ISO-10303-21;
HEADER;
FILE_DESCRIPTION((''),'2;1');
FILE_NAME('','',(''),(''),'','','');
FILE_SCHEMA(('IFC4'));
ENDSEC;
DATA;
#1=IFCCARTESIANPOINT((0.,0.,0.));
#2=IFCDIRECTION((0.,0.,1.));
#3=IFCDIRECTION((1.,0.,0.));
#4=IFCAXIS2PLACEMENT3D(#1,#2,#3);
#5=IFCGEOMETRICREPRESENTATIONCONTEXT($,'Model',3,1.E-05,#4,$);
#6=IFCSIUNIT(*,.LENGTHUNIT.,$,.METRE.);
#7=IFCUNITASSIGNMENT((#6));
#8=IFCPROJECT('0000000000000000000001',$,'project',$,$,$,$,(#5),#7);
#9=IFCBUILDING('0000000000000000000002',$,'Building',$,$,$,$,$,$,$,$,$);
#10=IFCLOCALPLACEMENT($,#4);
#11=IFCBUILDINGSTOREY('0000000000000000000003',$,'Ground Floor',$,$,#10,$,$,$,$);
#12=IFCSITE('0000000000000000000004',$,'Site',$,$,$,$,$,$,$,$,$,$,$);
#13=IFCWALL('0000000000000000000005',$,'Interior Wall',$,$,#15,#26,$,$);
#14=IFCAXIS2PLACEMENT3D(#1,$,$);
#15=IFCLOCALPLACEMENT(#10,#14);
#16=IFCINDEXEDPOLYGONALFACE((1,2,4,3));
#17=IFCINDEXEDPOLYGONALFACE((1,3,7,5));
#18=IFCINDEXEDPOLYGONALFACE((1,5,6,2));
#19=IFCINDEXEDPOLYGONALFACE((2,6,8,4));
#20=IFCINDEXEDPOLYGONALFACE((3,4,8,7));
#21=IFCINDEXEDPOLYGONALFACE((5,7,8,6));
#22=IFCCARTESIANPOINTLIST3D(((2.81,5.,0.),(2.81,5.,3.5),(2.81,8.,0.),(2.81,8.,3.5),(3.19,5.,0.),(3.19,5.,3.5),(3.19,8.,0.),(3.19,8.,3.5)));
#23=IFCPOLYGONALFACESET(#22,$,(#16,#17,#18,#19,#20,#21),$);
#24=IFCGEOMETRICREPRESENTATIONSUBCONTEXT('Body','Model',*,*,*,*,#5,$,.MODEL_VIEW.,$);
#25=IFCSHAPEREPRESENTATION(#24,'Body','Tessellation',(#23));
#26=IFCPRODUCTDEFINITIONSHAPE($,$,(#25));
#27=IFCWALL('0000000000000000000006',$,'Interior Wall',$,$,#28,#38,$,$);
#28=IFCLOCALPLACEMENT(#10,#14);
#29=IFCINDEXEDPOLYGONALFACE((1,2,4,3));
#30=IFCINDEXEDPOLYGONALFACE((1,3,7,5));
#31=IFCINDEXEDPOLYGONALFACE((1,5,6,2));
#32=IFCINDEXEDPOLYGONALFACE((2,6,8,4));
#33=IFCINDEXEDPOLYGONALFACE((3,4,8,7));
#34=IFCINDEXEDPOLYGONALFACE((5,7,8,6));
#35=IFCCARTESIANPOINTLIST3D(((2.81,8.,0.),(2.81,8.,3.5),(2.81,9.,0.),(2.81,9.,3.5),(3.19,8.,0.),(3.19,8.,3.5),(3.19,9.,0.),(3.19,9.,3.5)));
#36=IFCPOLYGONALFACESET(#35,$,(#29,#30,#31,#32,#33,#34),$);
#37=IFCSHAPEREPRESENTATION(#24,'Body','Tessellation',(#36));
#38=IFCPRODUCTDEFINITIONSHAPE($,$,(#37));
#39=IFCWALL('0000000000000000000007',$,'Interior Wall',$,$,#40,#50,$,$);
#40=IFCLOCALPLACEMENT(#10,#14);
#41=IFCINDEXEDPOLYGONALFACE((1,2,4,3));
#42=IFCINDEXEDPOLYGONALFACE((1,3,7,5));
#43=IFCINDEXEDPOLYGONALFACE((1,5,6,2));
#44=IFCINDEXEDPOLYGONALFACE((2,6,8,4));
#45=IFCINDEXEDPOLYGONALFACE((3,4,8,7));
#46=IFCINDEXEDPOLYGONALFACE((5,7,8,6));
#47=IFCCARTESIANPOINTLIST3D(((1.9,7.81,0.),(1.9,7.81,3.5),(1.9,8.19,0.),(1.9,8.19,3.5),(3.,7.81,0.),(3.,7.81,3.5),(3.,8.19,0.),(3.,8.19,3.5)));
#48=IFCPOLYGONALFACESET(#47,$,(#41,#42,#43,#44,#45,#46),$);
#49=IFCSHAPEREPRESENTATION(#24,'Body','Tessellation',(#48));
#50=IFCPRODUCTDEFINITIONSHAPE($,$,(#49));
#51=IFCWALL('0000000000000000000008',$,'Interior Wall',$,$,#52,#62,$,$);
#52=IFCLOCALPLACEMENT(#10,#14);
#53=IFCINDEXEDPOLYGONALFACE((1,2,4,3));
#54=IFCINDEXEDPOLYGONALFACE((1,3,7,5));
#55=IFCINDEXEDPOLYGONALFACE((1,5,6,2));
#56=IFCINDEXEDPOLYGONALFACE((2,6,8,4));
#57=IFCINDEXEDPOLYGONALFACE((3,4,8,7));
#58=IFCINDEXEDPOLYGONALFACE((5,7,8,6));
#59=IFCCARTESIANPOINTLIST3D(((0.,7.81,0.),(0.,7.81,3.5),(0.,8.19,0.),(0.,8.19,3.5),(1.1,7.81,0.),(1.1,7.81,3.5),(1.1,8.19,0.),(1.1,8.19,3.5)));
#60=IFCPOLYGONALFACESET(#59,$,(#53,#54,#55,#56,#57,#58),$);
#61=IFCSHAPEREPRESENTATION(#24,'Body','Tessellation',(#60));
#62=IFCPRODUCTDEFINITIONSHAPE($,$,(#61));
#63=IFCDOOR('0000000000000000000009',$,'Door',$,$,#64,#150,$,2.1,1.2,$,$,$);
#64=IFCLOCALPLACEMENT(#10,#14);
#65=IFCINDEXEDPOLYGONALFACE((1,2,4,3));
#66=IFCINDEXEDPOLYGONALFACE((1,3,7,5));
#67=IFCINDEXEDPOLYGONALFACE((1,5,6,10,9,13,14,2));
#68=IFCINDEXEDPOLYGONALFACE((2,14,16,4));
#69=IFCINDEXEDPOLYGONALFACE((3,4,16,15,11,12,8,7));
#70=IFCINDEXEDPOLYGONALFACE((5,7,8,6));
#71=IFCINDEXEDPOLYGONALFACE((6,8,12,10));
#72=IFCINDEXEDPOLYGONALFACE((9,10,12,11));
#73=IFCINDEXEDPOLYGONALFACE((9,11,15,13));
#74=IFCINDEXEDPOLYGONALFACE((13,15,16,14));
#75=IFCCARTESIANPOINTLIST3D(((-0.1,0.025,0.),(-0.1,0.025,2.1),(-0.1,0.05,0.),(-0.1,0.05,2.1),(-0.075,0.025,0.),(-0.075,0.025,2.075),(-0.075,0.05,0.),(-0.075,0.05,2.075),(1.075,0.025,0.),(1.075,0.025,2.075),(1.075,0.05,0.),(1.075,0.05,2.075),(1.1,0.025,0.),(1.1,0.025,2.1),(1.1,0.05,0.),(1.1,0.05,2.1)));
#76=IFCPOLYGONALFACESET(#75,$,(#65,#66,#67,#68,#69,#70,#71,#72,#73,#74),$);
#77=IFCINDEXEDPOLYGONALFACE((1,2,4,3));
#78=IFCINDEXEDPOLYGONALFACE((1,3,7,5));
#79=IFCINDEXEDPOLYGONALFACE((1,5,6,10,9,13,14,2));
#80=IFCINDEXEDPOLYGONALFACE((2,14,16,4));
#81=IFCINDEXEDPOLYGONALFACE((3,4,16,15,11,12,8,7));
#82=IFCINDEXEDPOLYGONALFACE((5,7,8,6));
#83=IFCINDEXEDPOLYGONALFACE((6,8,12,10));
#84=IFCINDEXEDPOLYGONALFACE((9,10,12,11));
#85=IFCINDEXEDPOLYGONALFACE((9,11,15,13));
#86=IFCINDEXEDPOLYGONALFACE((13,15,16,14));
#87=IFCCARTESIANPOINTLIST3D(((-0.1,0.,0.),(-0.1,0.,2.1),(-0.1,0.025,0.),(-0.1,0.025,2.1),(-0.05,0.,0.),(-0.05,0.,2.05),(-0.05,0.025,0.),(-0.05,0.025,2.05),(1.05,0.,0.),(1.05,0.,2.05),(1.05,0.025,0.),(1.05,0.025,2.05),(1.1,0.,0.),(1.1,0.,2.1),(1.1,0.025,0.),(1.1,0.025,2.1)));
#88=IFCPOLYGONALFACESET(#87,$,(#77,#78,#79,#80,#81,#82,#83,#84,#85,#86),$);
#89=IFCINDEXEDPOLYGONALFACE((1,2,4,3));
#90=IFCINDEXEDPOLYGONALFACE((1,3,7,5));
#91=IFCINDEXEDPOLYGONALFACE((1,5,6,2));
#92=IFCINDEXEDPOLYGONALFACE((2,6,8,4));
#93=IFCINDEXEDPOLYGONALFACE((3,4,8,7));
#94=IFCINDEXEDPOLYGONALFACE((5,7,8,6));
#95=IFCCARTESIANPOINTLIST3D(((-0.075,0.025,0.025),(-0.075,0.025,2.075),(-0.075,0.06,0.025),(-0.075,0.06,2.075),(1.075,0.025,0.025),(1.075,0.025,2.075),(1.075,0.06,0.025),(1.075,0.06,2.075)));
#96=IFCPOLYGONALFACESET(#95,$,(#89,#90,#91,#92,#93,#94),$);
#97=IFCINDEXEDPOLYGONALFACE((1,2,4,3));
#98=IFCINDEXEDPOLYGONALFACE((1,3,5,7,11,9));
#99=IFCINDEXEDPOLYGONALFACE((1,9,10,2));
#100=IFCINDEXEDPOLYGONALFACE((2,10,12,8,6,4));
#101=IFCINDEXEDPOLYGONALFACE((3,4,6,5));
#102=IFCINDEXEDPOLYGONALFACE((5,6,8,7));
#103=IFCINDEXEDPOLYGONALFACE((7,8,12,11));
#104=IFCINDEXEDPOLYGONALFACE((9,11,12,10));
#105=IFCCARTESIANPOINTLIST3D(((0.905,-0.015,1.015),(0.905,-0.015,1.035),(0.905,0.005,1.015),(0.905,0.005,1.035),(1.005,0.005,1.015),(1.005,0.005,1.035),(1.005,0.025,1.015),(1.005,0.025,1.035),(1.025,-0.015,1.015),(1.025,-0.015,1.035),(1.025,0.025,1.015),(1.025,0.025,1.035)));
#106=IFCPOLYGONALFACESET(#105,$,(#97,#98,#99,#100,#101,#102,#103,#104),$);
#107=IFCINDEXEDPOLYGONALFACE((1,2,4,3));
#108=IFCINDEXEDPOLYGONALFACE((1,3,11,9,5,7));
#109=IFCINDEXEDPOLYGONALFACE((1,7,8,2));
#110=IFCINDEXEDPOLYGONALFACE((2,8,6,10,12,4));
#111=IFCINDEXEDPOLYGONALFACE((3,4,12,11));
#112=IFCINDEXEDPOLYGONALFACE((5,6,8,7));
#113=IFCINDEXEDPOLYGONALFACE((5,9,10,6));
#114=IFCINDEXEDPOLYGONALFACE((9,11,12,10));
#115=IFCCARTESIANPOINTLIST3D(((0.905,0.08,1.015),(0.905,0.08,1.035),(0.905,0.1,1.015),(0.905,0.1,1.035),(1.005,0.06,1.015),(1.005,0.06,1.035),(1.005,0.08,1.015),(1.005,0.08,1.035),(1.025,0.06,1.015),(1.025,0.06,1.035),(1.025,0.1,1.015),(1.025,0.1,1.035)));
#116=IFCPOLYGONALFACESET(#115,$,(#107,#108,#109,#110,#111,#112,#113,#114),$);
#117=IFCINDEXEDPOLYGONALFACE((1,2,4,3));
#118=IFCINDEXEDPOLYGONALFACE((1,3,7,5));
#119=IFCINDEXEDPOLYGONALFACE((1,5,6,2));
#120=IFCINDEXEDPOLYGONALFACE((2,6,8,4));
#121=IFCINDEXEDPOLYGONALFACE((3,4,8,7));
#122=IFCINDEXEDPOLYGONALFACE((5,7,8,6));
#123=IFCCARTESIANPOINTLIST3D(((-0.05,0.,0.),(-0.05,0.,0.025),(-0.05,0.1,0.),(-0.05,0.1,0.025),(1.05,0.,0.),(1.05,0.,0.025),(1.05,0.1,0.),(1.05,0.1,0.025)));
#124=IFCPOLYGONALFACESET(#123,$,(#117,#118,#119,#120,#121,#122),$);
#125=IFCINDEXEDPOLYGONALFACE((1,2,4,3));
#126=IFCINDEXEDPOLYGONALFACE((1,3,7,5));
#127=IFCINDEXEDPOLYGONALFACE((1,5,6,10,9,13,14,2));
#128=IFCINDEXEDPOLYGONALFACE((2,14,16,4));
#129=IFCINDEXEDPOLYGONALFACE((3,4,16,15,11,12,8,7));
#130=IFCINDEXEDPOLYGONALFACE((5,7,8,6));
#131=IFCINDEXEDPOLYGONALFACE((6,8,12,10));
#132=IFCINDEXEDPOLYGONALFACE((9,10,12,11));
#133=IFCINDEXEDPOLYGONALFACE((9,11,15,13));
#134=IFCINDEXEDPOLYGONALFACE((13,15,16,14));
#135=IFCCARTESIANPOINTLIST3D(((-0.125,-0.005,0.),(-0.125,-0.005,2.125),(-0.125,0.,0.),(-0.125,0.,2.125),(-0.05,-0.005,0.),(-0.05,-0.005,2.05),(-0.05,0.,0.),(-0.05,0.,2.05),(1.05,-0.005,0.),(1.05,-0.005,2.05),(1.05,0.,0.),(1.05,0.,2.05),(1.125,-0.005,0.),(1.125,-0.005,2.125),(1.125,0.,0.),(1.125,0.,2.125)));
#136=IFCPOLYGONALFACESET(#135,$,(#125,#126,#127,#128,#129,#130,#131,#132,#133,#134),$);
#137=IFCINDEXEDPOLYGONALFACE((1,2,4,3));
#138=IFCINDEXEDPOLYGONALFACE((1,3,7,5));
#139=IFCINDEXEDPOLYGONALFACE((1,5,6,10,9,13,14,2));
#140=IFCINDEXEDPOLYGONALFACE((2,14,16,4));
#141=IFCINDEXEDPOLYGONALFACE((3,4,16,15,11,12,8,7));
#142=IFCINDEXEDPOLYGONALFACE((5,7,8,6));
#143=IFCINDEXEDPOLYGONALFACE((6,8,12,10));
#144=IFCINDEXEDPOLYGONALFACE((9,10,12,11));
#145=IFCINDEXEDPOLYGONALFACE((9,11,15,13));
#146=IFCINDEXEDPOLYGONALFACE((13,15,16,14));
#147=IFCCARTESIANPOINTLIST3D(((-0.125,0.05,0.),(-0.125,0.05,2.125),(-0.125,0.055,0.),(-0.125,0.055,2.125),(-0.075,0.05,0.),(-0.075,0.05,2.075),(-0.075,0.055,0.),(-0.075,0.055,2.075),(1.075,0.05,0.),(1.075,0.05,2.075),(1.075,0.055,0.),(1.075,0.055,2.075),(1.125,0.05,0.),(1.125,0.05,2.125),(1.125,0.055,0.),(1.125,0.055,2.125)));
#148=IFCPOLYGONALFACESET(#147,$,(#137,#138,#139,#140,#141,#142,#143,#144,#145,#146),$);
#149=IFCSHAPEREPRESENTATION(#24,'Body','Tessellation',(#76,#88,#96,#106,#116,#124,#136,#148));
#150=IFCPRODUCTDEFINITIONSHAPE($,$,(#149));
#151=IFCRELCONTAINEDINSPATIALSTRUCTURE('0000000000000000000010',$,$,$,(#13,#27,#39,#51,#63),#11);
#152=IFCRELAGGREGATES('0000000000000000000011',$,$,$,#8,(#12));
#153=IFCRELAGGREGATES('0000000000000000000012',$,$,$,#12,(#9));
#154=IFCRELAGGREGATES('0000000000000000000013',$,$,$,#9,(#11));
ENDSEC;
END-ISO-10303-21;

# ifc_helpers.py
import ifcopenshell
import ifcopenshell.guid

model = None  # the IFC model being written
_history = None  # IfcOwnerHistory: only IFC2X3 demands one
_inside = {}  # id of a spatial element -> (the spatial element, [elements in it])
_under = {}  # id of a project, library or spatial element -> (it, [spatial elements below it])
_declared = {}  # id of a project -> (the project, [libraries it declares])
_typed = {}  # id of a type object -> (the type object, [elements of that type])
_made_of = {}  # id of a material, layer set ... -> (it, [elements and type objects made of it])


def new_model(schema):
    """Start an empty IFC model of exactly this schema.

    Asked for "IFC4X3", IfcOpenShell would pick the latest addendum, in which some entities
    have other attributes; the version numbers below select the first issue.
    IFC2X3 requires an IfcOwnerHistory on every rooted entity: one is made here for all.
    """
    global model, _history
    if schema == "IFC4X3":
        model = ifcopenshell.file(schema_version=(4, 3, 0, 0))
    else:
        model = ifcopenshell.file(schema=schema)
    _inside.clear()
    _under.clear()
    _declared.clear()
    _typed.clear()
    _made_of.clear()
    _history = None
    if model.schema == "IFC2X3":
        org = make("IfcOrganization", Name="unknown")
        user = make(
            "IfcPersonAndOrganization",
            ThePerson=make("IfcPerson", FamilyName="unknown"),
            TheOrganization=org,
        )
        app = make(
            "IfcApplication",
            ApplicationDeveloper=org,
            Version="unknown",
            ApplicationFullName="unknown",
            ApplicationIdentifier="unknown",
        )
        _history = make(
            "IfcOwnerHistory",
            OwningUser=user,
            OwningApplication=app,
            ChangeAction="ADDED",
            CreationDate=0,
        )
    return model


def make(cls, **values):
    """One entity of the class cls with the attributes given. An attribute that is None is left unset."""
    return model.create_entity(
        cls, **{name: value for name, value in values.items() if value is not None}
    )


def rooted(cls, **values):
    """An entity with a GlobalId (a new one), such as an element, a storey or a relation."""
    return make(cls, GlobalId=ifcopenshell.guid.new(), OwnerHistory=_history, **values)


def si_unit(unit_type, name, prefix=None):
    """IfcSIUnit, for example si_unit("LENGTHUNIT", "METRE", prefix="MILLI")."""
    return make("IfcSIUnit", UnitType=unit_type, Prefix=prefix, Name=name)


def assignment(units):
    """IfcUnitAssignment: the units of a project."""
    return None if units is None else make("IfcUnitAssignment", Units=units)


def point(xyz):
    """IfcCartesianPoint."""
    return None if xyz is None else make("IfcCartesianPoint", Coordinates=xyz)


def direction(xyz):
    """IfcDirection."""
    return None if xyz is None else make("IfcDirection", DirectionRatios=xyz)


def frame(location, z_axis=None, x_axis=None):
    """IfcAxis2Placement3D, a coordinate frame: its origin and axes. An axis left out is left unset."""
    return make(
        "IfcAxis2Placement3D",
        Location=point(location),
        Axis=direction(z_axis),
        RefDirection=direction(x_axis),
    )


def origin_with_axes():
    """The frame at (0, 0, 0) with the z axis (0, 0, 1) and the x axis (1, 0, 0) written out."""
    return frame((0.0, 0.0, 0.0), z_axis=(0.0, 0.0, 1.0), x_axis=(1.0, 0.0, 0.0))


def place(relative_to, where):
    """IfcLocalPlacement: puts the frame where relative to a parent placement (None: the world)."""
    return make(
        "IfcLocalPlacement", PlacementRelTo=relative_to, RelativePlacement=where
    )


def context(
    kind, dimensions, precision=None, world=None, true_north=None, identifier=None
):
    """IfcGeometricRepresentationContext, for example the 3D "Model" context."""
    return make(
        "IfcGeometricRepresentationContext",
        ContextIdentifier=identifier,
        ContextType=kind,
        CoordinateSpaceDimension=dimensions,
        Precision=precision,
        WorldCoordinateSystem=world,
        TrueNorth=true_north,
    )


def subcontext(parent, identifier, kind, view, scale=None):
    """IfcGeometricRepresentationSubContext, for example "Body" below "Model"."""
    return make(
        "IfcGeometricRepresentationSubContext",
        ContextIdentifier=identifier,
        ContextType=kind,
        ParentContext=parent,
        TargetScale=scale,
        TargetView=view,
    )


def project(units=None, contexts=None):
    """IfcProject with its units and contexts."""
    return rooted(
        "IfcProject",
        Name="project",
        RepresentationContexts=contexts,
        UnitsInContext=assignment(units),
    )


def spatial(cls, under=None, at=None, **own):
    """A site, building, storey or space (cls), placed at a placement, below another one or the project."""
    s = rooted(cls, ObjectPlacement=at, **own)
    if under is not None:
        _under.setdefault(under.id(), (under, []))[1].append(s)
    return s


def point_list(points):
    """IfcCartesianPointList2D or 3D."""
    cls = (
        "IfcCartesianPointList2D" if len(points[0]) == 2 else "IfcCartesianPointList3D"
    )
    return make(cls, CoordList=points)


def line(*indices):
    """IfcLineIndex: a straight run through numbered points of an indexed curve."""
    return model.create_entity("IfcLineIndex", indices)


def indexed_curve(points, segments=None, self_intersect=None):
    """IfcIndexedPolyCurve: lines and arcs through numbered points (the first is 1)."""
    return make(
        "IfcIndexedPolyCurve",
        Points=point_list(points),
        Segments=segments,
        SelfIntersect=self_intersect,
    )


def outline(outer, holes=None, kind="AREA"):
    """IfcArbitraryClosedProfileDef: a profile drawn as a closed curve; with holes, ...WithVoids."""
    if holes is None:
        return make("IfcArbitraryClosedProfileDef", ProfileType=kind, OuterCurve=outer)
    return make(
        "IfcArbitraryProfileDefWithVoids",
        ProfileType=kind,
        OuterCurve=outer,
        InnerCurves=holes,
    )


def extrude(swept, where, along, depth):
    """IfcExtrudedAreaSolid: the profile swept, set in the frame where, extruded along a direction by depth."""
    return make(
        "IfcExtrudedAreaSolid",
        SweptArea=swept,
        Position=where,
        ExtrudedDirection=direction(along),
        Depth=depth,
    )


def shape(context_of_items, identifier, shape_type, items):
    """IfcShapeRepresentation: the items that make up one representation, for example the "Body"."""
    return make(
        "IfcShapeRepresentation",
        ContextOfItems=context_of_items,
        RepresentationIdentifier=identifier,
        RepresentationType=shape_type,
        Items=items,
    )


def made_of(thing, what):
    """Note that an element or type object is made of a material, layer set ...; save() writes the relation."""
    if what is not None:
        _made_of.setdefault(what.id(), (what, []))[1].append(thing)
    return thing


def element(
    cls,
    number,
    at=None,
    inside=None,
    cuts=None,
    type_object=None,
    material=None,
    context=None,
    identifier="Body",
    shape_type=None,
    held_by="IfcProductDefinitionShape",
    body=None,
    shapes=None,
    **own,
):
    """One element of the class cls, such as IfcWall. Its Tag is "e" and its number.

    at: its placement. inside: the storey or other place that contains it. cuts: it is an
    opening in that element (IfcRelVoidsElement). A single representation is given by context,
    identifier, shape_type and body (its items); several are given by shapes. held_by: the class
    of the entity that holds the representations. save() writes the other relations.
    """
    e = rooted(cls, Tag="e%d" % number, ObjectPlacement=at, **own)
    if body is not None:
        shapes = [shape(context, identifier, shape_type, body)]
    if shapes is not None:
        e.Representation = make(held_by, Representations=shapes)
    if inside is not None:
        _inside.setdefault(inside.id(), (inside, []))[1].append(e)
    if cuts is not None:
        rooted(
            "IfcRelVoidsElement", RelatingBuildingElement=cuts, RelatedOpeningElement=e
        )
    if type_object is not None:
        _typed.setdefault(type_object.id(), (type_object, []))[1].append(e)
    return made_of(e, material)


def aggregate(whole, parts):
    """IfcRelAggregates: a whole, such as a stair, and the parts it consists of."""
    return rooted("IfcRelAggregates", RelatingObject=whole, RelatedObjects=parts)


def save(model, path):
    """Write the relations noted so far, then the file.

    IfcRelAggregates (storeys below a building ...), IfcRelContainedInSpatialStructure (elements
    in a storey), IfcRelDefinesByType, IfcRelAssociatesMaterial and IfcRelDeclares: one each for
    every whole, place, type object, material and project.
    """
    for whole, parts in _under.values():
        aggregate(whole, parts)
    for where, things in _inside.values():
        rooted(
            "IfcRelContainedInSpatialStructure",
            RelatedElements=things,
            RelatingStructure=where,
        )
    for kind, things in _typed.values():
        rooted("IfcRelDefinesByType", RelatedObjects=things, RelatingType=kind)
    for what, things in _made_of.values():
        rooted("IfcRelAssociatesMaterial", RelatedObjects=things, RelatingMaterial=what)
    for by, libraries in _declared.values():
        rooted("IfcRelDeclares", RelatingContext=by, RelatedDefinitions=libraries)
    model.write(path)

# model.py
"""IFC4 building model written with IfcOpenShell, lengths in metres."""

from ifc_helpers import new_model, si_unit, frame, origin_with_axes, place, context, subcontext, project, spatial, line, indexed_curve, outline, extrude, element, save


model = new_model("IFC4")

# Units and contexts
model_context = context("Model", 3, precision=1e-05, world=origin_with_axes())
body_context = subcontext(model_context, "Body", "Model", "MODEL_VIEW")
ifc_project = project(units=[si_unit("LENGTHUNIT", "METRE")], contexts=[model_context])

# Site, building, storey
site = spatial("IfcSite", under=ifc_project, Name="Site")
building = spatial("IfcBuilding", under=site, Name="Building")
storey_placement = place(None, origin_with_axes())
storey = spatial("IfcBuildingStorey", under=building, at=storey_placement, Name="Ground Floor")

# Walls
wall_1_placement = place(storey_placement, frame((3.0, 8.0, 0.0), z_axis=(0.0, 0.0, 1.0), x_axis=(0.0, -1.0, 0.0)))
element("IfcWall", 1, at=wall_1_placement, inside=storey, Name="Interior Wall", context=body_context, shape_type="SweptSolid", body=[
    extrude(outline(indexed_curve([(0.0, 0.0), (0.0, 0.38), (3.0, 0.38), (3.0, 0.0), (0.0, 0.0)], self_intersect=False)), frame((0.0, -0.19, 0.0), z_axis=(0.0, 0.0, 1.0), x_axis=(1.0, 0.0, 0.0)), (0.0, 0.0, 1.0), 3.5),
])
wall_2_placement = place(storey_placement, frame((3.0, 9.0, 0.0), z_axis=(0.0, 0.0, 1.0), x_axis=(0.0, -1.0, 0.0)))
element("IfcWall", 2, at=wall_2_placement, inside=storey, Name="Interior Wall", context=body_context, shape_type="SweptSolid", body=[
    extrude(outline(indexed_curve([(0.0, 0.0), (0.0, 0.38), (1.0, 0.38), (1.0, 0.0), (0.0, 0.0)], self_intersect=False)), frame((0.0, -0.19, 0.0), z_axis=(0.0, 0.0, 1.0), x_axis=(1.0, 0.0, 0.0)), (0.0, 0.0, 1.0), 3.5),
])
for number, where, z_axis, x_axis, name in (
    (3, (3.0, 8.0, 0.0), (0.0, 0.0, 1.0), (-1.0, 0.0, 0.0), "Interior Wall"),
    (4, (1.1, 8.0, 0.0), (0.0, 0.0, 1.0), (-1.0, 0.0, 0.0), "Interior Wall"),
):
    element("IfcWall", number, at=place(storey_placement, frame(where, z_axis=z_axis, x_axis=x_axis)), inside=storey, Name=name, context=body_context, shape_type="SweptSolid", body=[
        extrude(outline(indexed_curve([(0.0, 0.0), (0.0, 0.38), (1.1, 0.38), (1.1, 0.0), (0.0, 0.0)], self_intersect=False)), frame((0.0, -0.19, 0.0), z_axis=(0.0, 0.0, 1.0), x_axis=(1.0, 0.0, 0.0)), (0.0, 0.0, 1.0), 3.5),
    ])

# Door
door_1_placement = place(storey_placement, frame((-0.1, 0.0, 0.0), z_axis=(0.0, 0.0, 1.0), x_axis=(1.0, 0.0, 0.0)))
element("IfcDoor", 5, at=door_1_placement, inside=storey, Name="Door", OverallHeight=2.1, OverallWidth=1.2, context=body_context, shape_type="SweptSolid", body=[
    extrude(outline(indexed_curve([(0.0, 0.0), (0.0, 2.1), (1.2, 2.1), (1.2, 0.0), (1.175, 0.0), (1.175, 2.075), (0.025, 2.075), (0.025, 0.0)], segments=[line(1, 2, 3, 4, 5, 6, 7, 8, 1)])), frame((0.0, 0.025, 0.0), z_axis=(0.0, -1.0, 0.0), x_axis=(1.0, 0.0, 0.0)), (0.0, 0.0, -1.0), 0.025),
    extrude(outline(indexed_curve([(0.0, 0.0), (0.0, 2.1), (1.2, 2.1), (1.2, 0.0), (1.15, 0.0), (1.15, 2.05), (0.05, 2.05), (0.05, 0.0)], segments=[line(1, 2, 3, 4, 5, 6, 7, 8, 1)])), frame((0.0, 0.0, 0.0), z_axis=(0.0, -1.0, 0.0), x_axis=(1.0, 0.0, 0.0)), (0.0, 0.0, -1.0), 0.025),
    extrude(outline(indexed_curve([(0.0, 0.0), (1.15, 0.0), (1.15, 0.035), (0.0, 0.035)], segments=[line(1, 2, 3, 4, 1)])), frame((0.025, 0.025, 0.025), z_axis=(0.0, 0.0, 1.0), x_axis=(1.0, 0.0, 0.0)), (0.0, 0.0, 1.0), 2.05),
    extrude(outline(indexed_curve([(0.0, 0.0), (0.0, -0.04), (-0.12, -0.04), (-0.12, -0.02), (-0.02, -0.02), (-0.02, 0.0)], segments=[line(1, 2, 3, 4, 5, 6, 1)])), frame((1.125, 0.025, 1.015), z_axis=(0.0, 0.0, 1.0), x_axis=(1.0, 0.0, 0.0)), (0.0, 0.0, 1.0), 0.02),
    extrude(outline(indexed_curve([(0.0, 0.0), (0.0, 0.04), (-0.12, 0.04), (-0.12, 0.02), (-0.02, 0.02), (-0.02, 0.0)], segments=[line(1, 2, 3, 4, 5, 6, 1)])), frame((1.125, 0.06, 1.015), z_axis=(0.0, 0.0, 1.0), x_axis=(1.0, 0.0, 0.0)), (0.0, 0.0, 1.0), 0.02),
    extrude(outline(indexed_curve([(0.0, 0.0), (1.1, 0.0), (1.1, 0.1), (0.0, 0.1)], segments=[line(1, 2, 3, 4, 1)])), frame((0.05, 0.0, 0.0), z_axis=(0.0, 0.0, 1.0), x_axis=(1.0, 0.0, 0.0)), (0.0, 0.0, 1.0), 0.025),
    extrude(outline(indexed_curve([(0.0, 0.0), (0.0, 2.125), (1.25, 2.125), (1.25, 0.0), (1.175, 0.0), (1.175, 2.05), (0.075, 2.05), (0.075, 0.0)], segments=[line(1, 2, 3, 4, 5, 6, 7, 8, 1)])), frame((-0.025, -0.005, 0.0), z_axis=(0.0, -1.0, 0.0), x_axis=(1.0, 0.0, 0.0)), (0.0, 0.0, -1.0), 0.005),
    extrude(outline(indexed_curve([(0.0, 0.0), (0.0, 2.125), (1.25, 2.125), (1.25, 0.0), (1.2, 0.0), (1.2, 2.075), (0.05, 2.075), (0.05, 0.0)], segments=[line(1, 2, 3, 4, 5, 6, 7, 8, 1)])), frame((-0.025, 0.05, 0.0), z_axis=(0.0, -1.0, 0.0), x_axis=(1.0, 0.0, 0.0)), (0.0, 0.0, -1.0), 0.005),
])

save(model, "model.ifc")
